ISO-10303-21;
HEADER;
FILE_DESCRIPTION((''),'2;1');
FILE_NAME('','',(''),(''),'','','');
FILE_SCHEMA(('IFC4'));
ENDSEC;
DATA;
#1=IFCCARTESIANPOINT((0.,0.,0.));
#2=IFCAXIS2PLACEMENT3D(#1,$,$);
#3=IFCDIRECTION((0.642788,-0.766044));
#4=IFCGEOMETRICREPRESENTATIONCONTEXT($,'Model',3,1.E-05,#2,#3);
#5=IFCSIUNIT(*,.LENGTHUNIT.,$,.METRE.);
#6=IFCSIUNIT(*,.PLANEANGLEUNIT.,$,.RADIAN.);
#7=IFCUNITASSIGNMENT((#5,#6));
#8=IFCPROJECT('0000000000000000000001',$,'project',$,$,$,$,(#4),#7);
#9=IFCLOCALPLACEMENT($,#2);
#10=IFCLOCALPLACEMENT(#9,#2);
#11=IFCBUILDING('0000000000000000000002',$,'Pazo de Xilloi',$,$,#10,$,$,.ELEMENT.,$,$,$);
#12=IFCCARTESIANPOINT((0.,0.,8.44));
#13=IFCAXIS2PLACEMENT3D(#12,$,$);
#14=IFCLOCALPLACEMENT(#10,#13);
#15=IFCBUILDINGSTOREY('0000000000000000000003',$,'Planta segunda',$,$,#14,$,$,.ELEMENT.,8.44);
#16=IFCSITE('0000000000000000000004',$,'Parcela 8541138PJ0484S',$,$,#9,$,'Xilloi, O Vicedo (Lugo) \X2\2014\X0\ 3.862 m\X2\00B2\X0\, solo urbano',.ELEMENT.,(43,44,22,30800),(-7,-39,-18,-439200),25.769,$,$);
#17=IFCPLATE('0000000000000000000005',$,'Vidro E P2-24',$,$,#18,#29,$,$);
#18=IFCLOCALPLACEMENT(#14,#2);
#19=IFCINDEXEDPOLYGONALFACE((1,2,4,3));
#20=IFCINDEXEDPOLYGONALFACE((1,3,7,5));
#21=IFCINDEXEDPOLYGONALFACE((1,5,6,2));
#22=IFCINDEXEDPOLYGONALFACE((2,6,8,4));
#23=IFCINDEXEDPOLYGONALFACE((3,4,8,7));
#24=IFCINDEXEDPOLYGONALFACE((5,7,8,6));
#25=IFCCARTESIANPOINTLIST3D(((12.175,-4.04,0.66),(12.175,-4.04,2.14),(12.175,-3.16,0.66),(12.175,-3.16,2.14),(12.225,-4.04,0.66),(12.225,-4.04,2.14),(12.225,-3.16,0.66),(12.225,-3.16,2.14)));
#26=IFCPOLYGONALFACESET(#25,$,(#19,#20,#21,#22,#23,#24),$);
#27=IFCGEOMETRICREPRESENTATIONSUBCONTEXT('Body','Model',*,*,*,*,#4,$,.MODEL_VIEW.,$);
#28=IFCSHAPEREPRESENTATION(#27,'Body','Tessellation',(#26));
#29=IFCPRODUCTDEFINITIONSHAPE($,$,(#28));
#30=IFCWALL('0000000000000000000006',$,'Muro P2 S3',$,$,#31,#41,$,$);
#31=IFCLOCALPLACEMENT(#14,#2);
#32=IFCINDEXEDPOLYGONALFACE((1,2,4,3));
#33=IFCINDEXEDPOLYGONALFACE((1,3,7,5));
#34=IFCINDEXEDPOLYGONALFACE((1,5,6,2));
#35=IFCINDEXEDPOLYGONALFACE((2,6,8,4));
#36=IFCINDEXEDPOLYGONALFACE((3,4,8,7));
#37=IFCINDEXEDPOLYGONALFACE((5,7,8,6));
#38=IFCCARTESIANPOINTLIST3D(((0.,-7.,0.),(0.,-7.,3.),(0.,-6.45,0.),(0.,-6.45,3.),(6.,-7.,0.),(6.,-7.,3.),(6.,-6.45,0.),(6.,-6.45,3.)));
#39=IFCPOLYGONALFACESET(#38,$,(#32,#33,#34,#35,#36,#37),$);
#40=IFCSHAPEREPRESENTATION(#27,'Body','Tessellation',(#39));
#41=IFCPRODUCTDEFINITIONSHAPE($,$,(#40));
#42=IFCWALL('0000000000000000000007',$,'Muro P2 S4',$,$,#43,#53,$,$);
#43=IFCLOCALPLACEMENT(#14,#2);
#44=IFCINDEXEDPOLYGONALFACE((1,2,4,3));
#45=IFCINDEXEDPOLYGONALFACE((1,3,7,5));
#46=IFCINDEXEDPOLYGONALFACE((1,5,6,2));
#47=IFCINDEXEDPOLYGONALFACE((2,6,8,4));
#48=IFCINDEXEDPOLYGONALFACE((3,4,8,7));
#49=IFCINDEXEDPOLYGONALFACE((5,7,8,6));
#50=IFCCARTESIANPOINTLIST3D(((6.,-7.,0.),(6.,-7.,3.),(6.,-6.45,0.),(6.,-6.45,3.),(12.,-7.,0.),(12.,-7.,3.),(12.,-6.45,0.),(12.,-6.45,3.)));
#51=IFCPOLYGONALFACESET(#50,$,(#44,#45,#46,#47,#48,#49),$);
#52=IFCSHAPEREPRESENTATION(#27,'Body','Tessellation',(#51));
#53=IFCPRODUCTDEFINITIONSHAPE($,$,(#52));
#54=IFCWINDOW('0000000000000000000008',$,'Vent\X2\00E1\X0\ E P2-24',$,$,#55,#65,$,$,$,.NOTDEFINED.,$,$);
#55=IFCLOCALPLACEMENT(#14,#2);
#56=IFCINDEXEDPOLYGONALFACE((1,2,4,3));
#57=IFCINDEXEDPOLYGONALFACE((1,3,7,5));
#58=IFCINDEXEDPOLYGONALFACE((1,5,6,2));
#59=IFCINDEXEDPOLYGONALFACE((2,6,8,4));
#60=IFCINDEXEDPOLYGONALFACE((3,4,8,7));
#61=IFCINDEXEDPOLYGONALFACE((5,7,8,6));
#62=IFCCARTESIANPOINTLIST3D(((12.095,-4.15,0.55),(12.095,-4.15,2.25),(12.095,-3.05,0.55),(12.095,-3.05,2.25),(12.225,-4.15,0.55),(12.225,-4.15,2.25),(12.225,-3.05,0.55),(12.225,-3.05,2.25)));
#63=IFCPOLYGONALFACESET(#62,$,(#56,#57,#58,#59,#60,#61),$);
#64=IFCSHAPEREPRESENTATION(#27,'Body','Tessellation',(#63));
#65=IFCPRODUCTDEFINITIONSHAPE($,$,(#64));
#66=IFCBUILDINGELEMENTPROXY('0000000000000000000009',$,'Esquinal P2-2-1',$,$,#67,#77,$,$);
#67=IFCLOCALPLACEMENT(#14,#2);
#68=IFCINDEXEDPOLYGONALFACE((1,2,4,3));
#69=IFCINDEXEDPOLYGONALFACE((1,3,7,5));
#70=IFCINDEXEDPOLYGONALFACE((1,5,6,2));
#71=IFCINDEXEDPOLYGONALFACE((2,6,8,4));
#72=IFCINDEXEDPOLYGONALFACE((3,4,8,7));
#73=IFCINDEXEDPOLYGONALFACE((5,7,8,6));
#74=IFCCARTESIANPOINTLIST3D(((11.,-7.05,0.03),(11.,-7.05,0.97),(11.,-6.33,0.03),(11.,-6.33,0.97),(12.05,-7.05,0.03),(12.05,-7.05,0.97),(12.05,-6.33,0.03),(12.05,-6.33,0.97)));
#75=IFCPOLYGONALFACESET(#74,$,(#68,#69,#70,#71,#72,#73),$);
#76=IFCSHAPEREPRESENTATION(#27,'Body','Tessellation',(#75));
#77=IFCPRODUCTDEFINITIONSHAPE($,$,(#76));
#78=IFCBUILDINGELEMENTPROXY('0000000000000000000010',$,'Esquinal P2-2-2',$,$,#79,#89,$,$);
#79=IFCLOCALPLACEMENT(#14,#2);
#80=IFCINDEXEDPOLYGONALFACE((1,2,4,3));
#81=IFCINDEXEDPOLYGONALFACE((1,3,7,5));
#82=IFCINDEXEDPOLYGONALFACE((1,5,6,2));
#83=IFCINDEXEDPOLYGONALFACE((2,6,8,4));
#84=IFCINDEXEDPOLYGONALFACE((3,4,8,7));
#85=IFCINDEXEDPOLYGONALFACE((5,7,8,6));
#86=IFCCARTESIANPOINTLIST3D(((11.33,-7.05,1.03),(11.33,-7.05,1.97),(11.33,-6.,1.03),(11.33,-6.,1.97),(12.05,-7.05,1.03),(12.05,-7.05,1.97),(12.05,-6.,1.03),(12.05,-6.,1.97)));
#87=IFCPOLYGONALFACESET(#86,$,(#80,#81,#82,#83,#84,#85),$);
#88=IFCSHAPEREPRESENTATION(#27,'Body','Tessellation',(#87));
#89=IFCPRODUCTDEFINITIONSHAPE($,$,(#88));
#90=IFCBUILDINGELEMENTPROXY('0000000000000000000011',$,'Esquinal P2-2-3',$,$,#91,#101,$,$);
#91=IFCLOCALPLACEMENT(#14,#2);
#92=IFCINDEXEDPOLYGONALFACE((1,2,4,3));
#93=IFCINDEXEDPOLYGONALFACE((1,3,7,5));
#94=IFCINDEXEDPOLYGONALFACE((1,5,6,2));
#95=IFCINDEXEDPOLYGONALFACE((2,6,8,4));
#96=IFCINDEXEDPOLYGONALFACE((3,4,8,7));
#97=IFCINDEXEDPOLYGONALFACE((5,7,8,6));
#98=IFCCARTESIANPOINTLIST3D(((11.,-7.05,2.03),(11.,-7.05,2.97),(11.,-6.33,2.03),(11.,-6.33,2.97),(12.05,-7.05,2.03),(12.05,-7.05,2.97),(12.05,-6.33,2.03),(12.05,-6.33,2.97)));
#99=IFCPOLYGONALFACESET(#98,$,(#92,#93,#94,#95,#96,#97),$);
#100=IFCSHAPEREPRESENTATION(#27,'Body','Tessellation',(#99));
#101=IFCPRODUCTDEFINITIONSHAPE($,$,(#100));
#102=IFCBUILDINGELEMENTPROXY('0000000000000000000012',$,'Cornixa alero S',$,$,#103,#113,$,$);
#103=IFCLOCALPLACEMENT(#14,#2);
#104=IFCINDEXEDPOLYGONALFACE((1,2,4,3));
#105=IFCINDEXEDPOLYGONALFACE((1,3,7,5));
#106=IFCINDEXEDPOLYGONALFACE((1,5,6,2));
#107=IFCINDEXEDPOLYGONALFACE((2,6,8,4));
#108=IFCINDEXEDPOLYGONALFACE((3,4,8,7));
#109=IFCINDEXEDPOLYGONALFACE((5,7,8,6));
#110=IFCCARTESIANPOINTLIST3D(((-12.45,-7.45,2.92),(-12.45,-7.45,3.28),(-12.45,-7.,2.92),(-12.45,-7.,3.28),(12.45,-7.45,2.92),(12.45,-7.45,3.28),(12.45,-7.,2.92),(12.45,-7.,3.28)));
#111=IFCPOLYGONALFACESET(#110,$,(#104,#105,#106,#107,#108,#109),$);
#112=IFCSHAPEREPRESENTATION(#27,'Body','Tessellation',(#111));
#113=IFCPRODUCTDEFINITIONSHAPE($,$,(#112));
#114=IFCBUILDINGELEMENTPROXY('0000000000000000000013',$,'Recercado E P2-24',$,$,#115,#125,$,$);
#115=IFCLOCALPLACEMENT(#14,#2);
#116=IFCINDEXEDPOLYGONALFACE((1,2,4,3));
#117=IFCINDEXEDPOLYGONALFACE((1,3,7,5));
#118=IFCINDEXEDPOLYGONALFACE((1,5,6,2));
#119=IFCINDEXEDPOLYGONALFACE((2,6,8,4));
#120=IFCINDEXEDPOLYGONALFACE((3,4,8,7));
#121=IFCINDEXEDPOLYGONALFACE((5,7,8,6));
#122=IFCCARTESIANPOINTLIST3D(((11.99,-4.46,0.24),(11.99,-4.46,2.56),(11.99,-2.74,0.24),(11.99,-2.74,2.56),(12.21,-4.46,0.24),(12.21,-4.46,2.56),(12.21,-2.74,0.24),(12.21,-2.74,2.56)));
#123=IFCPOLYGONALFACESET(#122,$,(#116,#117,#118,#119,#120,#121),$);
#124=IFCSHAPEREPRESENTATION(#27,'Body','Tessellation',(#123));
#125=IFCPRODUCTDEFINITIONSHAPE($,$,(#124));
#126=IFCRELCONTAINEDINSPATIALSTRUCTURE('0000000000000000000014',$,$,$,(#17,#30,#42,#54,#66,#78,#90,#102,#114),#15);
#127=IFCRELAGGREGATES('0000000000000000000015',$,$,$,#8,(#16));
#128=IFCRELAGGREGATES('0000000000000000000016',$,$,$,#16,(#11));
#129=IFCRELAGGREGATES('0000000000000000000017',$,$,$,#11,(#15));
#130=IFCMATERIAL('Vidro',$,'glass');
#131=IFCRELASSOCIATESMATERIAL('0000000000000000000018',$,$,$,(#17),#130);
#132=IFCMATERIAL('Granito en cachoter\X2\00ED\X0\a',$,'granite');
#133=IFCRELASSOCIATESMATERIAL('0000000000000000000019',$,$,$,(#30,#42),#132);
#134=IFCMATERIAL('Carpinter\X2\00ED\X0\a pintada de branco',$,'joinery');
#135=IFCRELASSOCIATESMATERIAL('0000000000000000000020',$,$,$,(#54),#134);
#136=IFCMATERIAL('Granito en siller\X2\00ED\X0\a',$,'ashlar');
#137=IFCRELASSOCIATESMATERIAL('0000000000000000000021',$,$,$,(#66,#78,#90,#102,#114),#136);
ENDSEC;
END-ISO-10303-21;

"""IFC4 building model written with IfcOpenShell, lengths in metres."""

from ifc_helpers import new_model, si_unit, direction, frame, origin, origin_2d, place, context, subcontext, project, spatial, rectangle, extrude, material, element, save


model = new_model("IFC4")

# Units and contexts
model_context = context("Model", 3, precision=1e-05, world=origin(), true_north=direction((0.642788, -0.766044)))
body_context = subcontext(model_context, "Body", "Model", "MODEL_VIEW")
ifc_project = project(units=[si_unit("LENGTHUNIT", "METRE"), si_unit("PLANEANGLEUNIT", "RADIAN")], contexts=[model_context])

# Site, building, storey
site_placement = place(None, origin())
site = spatial("IfcSite", under=ifc_project, at=site_placement, Name="Parcela 8541138PJ0484S", LongName="Xilloi, O Vicedo (Lugo) — 3.862 m², solo urbano", CompositionType="ELEMENT", RefLatitude=(43, 44, 22, 30800), RefLongitude=(-7, -39, -18, -439200), RefElevation=25.769)
building_placement = place(site_placement, origin())
building = spatial("IfcBuilding", under=site, at=building_placement, Name="Pazo de Xilloi", CompositionType="ELEMENT")
storey_placement = place(building_placement, frame((0.0, 0.0, 8.44)))
storey = spatial("IfcBuildingStorey", under=building, at=storey_placement, Name="Planta segunda", CompositionType="ELEMENT", Elevation=8.44)

# Shared definitions
ifc_material_1 = material(Name="Carpintería pintada de branco", Category="joinery")

# Plate
ifc_material_2 = material(Name="Vidro", Category="glass")
plate_1_placement = place(storey_placement, frame((12.2, -3.6, 1.4)))
element("IfcPlate", 1, at=plate_1_placement, inside=storey, material=ifc_material_2, Name="Vidro E P2-24", context=body_context, shape_type="SweptSolid", body=[
    extrude(rectangle(XDim=0.05, YDim=0.88, at=origin_2d()), frame((0.0, 0.0, -0.74)), (0.0, 0.0, 1.0), 1.48),
])

# Walls
ifc_material_3 = material(Name="Granito en cachotería", Category="granite")
for number, where, name in (
    (2, (3.0, -6.725, 1.5), "Muro P2 S3"),
    (3, (9.0, -6.725, 1.5), "Muro P2 S4"),
):
    element("IfcWall", number, at=place(storey_placement, frame(where)), inside=storey, material=ifc_material_3, Name=name, context=body_context, shape_type="SweptSolid", body=[
        extrude(rectangle(XDim=6.0, YDim=0.55, at=origin_2d()), frame((0.0, 0.0, -1.5)), (0.0, 0.0, 1.0), 3.0),
    ])

# Window
window_placement = place(storey_placement, frame((12.16, -3.6, 1.4)))
element("IfcWindow", 4, at=window_placement, inside=storey, material=ifc_material_1, Name="Ventá E P2-24", PredefinedType="NOTDEFINED", context=body_context, shape_type="SweptSolid", body=[
    extrude(rectangle(XDim=0.13, YDim=1.1, at=origin_2d()), frame((0.0, 0.0, -0.85)), (0.0, 0.0, 1.0), 1.7),
])

# Building element proxies
ifc_material_4 = material(Name="Granito en sillería", Category="ashlar")
proxy_1_placement = place(storey_placement, frame((11.525, -6.69, 0.5)))
element("IfcBuildingElementProxy", 5, at=proxy_1_placement, inside=storey, material=ifc_material_4, Name="Esquinal P2-2-1", context=body_context, shape_type="SweptSolid", body=[
    extrude(rectangle(XDim=1.05, YDim=0.72, at=origin_2d()), frame((0.0, 0.0, -0.47)), (0.0, 0.0, 1.0), 0.94),
])
proxy_2_placement = place(storey_placement, frame((11.69, -6.525, 1.5)))
element("IfcBuildingElementProxy", 6, at=proxy_2_placement, inside=storey, material=ifc_material_4, Name="Esquinal P2-2-2", context=body_context, shape_type="SweptSolid", body=[
    extrude(rectangle(XDim=0.72, YDim=1.05, at=origin_2d()), frame((0.0, 0.0, -0.47)), (0.0, 0.0, 1.0), 0.94),
])
proxy_3_placement = place(storey_placement, frame((11.525, -6.69, 2.5)))
element("IfcBuildingElementProxy", 7, at=proxy_3_placement, inside=storey, material=ifc_material_4, Name="Esquinal P2-2-3", context=body_context, shape_type="SweptSolid", body=[
    extrude(rectangle(XDim=1.05, YDim=0.72, at=origin_2d()), frame((0.0, 0.0, -0.47)), (0.0, 0.0, 1.0), 0.94),
])
proxy_4_placement = place(storey_placement, frame((0.0, -7.225, 3.1)))
element("IfcBuildingElementProxy", 8, at=proxy_4_placement, inside=storey, material=ifc_material_4, Name="Cornixa alero S", context=body_context, shape_type="SweptSolid", body=[
    extrude(rectangle(XDim=24.9, YDim=0.45, at=origin_2d()), frame((0.0, 0.0, -0.18)), (0.0, 0.0, 1.0), 0.36),
])
proxy_5_placement = place(storey_placement, frame((12.1, -3.6, 1.4)))
element("IfcBuildingElementProxy", 9, at=proxy_5_placement, inside=storey, material=ifc_material_4, Name="Recercado E P2-24", context=body_context, shape_type="SweptSolid", body=[
    extrude(rectangle(XDim=0.22, YDim=1.72, at=origin_2d()), frame((0.0, 0.0, -1.16)), (0.0, 0.0, 1.0), 2.32),
])

save(model, "model.ifc")
